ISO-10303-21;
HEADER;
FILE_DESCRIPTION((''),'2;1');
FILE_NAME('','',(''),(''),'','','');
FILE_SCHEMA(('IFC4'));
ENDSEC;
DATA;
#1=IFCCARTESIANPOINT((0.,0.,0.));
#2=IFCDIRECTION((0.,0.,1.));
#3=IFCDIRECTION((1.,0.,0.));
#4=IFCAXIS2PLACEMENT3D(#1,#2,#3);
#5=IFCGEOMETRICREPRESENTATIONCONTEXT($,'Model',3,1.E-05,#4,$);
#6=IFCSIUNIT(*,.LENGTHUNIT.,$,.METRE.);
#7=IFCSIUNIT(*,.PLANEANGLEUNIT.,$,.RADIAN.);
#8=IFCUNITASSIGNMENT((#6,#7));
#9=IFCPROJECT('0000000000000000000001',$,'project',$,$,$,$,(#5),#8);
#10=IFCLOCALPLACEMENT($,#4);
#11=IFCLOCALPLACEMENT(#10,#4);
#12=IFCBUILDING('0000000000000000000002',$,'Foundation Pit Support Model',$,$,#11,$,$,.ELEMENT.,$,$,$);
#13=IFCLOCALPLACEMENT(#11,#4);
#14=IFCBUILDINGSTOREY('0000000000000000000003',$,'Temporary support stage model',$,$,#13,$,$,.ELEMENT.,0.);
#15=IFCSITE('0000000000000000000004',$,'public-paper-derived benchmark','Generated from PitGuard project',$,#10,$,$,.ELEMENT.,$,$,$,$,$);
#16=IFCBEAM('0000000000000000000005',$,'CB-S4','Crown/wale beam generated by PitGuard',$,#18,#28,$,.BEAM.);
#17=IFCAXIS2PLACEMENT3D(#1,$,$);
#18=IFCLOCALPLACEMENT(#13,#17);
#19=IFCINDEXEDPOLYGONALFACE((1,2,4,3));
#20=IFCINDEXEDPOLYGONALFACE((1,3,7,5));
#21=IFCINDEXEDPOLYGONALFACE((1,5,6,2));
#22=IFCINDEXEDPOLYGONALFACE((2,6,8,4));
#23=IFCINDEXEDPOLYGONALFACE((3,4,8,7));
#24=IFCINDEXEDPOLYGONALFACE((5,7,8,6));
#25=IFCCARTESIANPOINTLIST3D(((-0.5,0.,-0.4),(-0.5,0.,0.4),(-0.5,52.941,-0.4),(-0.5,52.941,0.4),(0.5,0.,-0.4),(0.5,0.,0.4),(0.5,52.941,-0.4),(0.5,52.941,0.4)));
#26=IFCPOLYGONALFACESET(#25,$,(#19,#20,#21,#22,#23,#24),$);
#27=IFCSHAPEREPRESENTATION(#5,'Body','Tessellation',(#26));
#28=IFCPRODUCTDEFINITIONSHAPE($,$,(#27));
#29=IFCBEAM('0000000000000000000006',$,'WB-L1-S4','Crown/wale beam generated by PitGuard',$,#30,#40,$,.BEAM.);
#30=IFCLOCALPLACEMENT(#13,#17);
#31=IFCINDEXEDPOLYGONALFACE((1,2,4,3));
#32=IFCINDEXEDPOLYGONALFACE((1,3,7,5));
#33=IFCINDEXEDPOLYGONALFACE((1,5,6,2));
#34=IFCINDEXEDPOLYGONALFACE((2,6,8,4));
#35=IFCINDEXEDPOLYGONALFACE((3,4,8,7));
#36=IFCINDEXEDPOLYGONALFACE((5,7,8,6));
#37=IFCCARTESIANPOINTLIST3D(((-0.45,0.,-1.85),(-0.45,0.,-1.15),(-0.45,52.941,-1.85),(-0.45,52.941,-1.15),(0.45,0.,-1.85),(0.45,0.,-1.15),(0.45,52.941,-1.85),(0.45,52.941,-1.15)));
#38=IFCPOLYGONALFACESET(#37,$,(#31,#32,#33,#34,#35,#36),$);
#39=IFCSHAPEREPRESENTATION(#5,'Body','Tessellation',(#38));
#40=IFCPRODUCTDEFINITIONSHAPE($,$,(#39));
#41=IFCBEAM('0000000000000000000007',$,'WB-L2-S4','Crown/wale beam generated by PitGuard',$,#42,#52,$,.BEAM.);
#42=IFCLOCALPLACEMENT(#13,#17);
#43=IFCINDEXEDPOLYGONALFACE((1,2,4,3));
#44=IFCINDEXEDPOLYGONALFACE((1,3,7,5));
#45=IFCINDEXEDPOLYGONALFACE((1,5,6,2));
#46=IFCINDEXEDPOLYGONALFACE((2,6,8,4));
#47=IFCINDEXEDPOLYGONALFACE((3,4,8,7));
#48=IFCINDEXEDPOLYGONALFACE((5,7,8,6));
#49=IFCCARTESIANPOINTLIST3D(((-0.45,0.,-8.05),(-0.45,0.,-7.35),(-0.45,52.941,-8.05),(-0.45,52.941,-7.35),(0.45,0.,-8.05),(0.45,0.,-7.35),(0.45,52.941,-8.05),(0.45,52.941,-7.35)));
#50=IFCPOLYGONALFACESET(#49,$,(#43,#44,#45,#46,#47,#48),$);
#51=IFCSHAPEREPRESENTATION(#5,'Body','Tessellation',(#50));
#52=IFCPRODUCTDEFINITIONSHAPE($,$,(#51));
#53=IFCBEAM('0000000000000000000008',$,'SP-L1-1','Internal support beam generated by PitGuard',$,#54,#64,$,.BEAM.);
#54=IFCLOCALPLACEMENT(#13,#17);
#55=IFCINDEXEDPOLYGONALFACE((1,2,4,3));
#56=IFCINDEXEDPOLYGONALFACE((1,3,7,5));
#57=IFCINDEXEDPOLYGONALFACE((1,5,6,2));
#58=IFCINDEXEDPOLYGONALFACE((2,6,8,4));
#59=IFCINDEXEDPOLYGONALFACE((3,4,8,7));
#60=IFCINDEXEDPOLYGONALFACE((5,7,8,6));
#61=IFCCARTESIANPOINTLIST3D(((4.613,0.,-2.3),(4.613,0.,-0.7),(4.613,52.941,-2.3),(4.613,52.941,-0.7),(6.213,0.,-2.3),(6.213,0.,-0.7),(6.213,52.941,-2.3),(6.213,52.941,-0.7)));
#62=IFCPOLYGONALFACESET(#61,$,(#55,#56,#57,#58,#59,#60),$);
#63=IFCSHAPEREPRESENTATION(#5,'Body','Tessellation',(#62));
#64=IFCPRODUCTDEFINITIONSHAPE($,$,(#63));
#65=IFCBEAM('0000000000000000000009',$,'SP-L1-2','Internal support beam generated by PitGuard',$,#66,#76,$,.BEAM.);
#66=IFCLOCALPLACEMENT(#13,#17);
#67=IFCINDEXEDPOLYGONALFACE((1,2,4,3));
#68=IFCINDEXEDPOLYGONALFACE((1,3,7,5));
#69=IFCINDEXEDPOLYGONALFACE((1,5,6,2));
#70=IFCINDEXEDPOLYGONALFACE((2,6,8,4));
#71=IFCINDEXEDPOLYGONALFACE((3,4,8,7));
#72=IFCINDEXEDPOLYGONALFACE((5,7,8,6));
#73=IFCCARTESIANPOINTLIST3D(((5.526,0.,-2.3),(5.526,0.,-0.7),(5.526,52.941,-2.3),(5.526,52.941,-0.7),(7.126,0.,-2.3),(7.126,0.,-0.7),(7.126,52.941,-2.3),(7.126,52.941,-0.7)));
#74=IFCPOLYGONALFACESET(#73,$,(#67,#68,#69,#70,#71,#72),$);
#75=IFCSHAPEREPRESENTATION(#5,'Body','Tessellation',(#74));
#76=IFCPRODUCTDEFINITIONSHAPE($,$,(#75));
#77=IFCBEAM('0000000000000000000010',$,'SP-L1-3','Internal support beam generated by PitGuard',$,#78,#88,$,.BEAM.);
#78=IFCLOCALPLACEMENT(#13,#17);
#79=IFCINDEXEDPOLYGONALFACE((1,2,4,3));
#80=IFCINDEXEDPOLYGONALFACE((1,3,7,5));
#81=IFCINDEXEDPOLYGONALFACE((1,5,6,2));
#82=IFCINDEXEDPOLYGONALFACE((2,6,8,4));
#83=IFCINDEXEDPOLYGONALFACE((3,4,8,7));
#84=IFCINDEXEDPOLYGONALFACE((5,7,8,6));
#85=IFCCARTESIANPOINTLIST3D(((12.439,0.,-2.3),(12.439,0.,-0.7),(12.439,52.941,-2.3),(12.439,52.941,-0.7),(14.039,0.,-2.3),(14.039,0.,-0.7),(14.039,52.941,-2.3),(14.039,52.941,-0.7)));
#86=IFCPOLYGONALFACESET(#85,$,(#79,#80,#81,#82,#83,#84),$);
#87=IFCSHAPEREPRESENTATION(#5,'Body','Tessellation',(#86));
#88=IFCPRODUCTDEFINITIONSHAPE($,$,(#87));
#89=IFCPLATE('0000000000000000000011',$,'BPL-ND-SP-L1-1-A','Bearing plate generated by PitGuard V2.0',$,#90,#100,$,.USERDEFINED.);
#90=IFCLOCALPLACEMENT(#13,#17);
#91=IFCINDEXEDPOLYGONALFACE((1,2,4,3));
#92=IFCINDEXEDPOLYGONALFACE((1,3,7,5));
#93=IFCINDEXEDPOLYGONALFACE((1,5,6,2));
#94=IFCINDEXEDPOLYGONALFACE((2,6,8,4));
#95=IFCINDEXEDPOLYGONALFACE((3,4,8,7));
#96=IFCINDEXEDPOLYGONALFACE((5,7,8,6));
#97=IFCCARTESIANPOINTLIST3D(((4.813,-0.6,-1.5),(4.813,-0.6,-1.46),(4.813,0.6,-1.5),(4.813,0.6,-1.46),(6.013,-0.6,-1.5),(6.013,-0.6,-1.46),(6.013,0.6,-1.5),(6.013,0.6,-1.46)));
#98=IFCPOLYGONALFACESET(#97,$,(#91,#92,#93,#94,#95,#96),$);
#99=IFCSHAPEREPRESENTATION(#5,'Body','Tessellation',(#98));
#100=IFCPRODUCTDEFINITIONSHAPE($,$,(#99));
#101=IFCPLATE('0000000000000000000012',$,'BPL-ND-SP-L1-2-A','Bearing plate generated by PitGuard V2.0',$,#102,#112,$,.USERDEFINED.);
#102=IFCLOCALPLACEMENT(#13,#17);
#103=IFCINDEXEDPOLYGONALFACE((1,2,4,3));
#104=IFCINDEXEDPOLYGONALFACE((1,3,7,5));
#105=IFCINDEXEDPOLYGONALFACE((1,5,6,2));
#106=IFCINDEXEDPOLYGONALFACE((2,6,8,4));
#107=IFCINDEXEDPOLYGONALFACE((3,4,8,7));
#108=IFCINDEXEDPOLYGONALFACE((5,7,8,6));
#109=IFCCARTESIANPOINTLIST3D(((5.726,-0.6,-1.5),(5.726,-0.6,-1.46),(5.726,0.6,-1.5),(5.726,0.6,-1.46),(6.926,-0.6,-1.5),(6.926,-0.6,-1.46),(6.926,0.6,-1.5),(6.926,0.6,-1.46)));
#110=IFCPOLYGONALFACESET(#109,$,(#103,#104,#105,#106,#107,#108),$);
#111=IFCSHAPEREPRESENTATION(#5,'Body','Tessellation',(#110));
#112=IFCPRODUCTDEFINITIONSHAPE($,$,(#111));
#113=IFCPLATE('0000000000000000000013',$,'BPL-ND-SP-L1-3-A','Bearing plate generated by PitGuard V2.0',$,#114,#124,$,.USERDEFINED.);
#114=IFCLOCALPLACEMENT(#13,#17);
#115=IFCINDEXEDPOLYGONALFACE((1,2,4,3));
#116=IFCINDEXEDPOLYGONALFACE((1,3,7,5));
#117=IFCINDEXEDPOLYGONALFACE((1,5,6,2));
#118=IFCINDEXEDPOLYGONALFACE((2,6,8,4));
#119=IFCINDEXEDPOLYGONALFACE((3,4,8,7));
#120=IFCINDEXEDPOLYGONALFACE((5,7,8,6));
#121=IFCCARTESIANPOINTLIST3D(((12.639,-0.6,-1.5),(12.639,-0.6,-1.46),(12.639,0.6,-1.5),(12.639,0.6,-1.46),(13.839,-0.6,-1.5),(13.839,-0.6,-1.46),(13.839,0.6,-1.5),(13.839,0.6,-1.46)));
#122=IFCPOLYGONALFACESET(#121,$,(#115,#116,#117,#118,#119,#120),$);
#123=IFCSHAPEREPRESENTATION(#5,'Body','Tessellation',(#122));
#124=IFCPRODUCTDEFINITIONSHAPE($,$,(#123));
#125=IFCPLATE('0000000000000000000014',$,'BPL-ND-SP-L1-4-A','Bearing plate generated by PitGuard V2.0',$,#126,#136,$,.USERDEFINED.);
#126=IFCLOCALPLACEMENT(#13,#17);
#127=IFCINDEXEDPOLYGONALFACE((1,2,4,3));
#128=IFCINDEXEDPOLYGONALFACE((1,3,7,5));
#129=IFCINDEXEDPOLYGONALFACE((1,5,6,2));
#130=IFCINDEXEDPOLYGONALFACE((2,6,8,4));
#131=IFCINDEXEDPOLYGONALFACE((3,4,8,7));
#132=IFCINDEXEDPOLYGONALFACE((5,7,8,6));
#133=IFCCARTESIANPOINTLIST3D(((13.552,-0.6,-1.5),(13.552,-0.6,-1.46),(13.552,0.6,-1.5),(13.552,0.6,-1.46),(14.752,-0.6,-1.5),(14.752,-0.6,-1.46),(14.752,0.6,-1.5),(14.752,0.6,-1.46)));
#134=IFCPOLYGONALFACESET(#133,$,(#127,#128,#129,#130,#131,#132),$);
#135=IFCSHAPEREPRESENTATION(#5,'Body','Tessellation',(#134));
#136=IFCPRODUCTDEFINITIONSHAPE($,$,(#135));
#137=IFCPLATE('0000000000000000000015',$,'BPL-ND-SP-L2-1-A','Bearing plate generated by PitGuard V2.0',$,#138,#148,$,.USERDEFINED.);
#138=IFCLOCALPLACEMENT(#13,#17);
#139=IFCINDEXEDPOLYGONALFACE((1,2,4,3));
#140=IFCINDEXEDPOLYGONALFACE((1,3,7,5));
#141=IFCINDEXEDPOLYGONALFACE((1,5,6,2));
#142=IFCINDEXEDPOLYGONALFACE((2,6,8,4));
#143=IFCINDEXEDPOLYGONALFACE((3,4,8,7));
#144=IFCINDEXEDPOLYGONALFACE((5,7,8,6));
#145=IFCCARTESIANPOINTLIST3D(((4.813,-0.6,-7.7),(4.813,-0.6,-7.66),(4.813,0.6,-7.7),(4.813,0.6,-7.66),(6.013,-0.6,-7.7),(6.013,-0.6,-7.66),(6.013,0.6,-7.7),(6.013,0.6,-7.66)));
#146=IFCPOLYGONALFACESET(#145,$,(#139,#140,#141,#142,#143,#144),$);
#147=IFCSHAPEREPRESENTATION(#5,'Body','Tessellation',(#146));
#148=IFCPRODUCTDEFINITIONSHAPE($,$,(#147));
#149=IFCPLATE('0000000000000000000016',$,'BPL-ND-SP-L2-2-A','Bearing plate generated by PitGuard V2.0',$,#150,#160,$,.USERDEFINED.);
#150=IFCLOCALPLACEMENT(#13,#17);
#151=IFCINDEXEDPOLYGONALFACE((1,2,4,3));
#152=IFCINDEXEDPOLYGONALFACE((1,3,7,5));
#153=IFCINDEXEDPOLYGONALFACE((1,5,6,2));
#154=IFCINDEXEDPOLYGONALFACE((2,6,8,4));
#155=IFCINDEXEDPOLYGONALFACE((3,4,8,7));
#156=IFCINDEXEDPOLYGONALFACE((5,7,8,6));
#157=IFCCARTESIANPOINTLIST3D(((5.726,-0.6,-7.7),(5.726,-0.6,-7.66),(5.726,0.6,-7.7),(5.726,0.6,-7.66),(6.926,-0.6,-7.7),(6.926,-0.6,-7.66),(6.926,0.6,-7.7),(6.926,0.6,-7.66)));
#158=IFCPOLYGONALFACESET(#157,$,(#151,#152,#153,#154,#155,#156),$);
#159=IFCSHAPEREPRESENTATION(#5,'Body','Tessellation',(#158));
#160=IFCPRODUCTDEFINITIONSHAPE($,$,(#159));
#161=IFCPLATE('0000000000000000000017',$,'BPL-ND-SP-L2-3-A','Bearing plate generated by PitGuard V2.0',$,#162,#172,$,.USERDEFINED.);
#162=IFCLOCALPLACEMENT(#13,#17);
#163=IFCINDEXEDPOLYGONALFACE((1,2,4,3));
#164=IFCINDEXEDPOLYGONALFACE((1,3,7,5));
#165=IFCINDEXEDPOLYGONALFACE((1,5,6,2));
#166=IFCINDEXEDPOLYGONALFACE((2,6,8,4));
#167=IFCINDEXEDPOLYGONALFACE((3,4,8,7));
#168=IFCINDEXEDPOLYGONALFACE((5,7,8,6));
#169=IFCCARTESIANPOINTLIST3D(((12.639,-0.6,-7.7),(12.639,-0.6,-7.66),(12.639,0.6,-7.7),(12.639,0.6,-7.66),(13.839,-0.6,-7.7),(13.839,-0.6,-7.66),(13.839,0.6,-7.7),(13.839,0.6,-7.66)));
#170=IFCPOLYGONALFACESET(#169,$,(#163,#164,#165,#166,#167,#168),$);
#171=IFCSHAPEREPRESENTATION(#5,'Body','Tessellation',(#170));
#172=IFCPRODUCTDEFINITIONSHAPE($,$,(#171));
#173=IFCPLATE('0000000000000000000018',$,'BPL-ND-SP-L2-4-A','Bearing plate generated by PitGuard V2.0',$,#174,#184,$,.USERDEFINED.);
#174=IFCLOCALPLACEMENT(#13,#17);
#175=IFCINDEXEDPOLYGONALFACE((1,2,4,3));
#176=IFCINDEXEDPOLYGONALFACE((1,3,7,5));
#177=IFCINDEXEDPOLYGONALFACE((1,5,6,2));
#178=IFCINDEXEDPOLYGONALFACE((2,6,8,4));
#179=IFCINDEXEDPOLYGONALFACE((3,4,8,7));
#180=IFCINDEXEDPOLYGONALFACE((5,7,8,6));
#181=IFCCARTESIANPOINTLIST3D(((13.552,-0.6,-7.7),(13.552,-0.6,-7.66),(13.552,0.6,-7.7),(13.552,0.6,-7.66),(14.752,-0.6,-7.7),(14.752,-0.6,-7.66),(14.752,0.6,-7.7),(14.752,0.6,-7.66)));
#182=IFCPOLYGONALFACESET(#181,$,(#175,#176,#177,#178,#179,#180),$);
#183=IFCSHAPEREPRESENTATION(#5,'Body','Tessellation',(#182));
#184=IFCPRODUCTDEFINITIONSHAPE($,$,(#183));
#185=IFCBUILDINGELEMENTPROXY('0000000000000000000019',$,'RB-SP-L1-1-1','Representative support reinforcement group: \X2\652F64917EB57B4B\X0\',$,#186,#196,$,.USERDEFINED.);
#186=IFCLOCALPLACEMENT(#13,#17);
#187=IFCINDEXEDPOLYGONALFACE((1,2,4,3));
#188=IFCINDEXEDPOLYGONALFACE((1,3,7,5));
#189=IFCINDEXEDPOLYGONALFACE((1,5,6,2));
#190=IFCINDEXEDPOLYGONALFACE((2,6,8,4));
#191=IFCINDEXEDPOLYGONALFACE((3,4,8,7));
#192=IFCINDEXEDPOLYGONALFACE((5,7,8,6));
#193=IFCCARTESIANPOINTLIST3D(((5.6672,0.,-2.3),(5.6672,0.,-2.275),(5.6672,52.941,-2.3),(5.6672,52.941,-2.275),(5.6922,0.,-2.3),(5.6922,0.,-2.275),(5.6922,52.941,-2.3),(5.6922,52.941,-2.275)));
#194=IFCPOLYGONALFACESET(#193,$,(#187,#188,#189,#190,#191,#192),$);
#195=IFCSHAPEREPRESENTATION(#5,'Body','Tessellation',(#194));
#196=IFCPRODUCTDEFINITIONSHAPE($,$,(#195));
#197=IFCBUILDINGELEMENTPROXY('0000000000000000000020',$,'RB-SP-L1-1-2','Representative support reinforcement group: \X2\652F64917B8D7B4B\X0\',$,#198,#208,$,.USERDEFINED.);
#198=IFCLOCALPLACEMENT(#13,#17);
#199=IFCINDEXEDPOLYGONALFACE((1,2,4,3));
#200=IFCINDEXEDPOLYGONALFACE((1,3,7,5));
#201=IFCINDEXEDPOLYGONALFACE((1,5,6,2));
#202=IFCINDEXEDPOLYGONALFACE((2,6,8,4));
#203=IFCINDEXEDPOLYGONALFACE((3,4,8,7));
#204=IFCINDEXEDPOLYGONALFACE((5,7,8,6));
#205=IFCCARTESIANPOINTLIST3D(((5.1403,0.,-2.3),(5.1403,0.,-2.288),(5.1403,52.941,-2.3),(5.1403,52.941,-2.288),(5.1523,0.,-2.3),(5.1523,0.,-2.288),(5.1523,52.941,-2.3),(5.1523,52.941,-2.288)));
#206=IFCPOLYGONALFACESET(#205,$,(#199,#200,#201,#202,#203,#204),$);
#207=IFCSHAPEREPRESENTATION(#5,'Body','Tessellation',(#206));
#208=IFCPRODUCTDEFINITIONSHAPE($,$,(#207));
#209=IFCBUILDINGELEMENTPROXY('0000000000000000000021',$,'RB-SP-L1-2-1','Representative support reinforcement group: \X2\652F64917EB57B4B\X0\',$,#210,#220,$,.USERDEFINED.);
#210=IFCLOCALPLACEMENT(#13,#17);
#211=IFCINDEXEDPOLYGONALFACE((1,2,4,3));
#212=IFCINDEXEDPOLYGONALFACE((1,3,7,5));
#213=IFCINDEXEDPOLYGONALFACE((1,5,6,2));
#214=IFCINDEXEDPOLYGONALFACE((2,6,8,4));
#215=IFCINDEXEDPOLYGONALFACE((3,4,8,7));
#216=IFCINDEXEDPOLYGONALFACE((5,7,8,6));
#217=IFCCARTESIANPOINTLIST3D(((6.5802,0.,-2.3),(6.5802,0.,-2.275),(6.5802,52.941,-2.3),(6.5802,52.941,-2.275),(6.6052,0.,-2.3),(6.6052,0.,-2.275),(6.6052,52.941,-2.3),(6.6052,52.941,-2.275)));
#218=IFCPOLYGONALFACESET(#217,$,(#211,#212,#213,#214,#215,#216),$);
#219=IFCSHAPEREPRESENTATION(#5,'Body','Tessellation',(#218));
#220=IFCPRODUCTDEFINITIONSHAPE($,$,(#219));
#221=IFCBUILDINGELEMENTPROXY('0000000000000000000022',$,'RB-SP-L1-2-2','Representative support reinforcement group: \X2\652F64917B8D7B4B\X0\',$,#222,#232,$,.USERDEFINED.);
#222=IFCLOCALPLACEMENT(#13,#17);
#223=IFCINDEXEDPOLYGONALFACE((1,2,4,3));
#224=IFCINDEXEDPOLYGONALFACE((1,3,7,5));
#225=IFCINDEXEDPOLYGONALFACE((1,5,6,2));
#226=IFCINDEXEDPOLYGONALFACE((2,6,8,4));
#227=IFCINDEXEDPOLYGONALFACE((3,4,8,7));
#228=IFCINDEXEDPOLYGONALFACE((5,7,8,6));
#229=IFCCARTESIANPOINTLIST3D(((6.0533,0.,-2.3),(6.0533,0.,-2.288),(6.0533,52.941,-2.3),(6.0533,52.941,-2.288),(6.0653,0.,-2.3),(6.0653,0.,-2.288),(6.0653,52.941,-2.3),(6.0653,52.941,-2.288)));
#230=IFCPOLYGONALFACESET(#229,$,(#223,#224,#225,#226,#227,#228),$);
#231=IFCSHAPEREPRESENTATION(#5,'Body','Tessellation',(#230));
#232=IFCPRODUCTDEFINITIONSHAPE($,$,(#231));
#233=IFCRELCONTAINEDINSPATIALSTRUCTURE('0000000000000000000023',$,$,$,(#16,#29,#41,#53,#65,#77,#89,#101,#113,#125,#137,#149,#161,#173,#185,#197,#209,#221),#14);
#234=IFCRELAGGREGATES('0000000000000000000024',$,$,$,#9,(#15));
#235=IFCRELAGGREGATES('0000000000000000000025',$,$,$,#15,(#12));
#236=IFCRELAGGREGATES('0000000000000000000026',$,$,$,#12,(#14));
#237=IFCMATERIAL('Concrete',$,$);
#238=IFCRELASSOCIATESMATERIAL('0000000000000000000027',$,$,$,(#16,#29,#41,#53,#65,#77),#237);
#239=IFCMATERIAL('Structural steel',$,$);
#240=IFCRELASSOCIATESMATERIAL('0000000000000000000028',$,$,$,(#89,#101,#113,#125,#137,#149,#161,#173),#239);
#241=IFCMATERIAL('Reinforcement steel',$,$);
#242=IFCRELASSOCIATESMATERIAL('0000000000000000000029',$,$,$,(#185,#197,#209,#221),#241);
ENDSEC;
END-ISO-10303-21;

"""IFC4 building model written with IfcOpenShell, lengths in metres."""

from ifc_helpers import new_model, si_unit, frame, origin_with_axes, origin_2d, place, context, project, spatial, rectangle, extrude, material, element, save


model = new_model("IFC4")

# Units and contexts
model_context = context("Model", 3, precision=1e-05, world=origin_with_axes())
ifc_project = project(units=[si_unit("LENGTHUNIT", "METRE"), si_unit("PLANEANGLEUNIT", "RADIAN")], contexts=[model_context])

# Site, building, storey
site_placement = place(None, origin_with_axes())
site = spatial("IfcSite", under=ifc_project, at=site_placement, Name="public-paper-derived benchmark", Description="Generated from PitGuard project", CompositionType="ELEMENT")
building_placement = place(site_placement, origin_with_axes())
building = spatial("IfcBuilding", under=site, at=building_placement, Name="Foundation Pit Support Model", CompositionType="ELEMENT")
storey_placement = place(building_placement, origin_with_axes())
storey = spatial("IfcBuildingStorey", under=building, at=storey_placement, Name="Temporary support stage model", CompositionType="ELEMENT", Elevation=0.0)

# Beams
ifc_material_1 = material(Name="Concrete")
beam_placement = place(storey_placement, frame((0.0, 26.4705, -0.4), z_axis=(0.0, 0.0, 1.0), x_axis=(0.0, -1.0, 0.0)))
element("IfcBeam", 1, at=beam_placement, inside=storey, material=ifc_material_1, Name="CB-S4", Description="Crown/wale beam generated by PitGuard", PredefinedType="BEAM", context=model_context, shape_type="SweptSolid", body=[
    extrude(rectangle(XDim=52.941, YDim=1.0, at=origin_2d()), origin_with_axes(), (0.0, 0.0, 1.0), 0.8),
])
for number, where, z_axis, x_axis, name in (
    (2, (0.0, 26.4705, -1.85), (0.0, 0.0, 1.0), (0.0, -1.0, 0.0), "WB-L1-S4"),
    (3, (0.0, 26.4705, -8.05), (0.0, 0.0, 1.0), (0.0, -1.0, 0.0), "WB-L2-S4"),
):
    element("IfcBeam", number, at=place(storey_placement, frame(where, z_axis=z_axis, x_axis=x_axis)), inside=storey, material=ifc_material_1, Name=name, Description="Crown/wale beam generated by PitGuard", PredefinedType="BEAM", context=model_context, shape_type="SweptSolid", body=[
        extrude(rectangle(XDim=52.941, YDim=0.9, at=origin_2d()), origin_with_axes(), (0.0, 0.0, 1.0), 0.7),
    ])
for number, where, z_axis, x_axis, name in (
    (4, (5.413, 26.4705, -2.3), (0.0, 0.0, 1.0), (0.0, 1.0, 0.0), "SP-L1-1"),
    (5, (6.326, 26.4705, -2.3), (0.0, 0.0, 1.0), (0.0, 1.0, 0.0), "SP-L1-2"),
    (6, (13.239, 26.4705, -2.3), (0.0, 0.0, 1.0), (0.0, 1.0, 0.0), "SP-L1-3"),
):
    element("IfcBeam", number, at=place(storey_placement, frame(where, z_axis=z_axis, x_axis=x_axis)), inside=storey, material=ifc_material_1, Name=name, Description="Internal support beam generated by PitGuard", PredefinedType="BEAM", context=model_context, shape_type="SweptSolid", body=[
        extrude(rectangle(XDim=52.941, YDim=1.6, at=origin_2d()), origin_with_axes(), (0.0, 0.0, 1.0), 1.6),
    ])

# Plates
ifc_material_2 = material(Name="Structural steel")
for number, where, z_axis, x_axis, name in (
    (7, (5.413, 0.0, -1.5), (0.0, 0.0, 1.0), (1.0, 0.0, 0.0), "BPL-ND-SP-L1-1-A"),
    (8, (6.326, 0.0, -1.5), (0.0, 0.0, 1.0), (1.0, 0.0, 0.0), "BPL-ND-SP-L1-2-A"),
    (9, (13.239, 0.0, -1.5), (0.0, 0.0, 1.0), (1.0, 0.0, 0.0), "BPL-ND-SP-L1-3-A"),
    (10, (14.152, 0.0, -1.5), (0.0, 0.0, 1.0), (1.0, 0.0, 0.0), "BPL-ND-SP-L1-4-A"),
    (11, (5.413, 0.0, -7.7), (0.0, 0.0, 1.0), (1.0, 0.0, 0.0), "BPL-ND-SP-L2-1-A"),
    (12, (6.326, 0.0, -7.7), (0.0, 0.0, 1.0), (1.0, 0.0, 0.0), "BPL-ND-SP-L2-2-A"),
    (13, (13.239, 0.0, -7.7), (0.0, 0.0, 1.0), (1.0, 0.0, 0.0), "BPL-ND-SP-L2-3-A"),
    (14, (14.152, 0.0, -7.7), (0.0, 0.0, 1.0), (1.0, 0.0, 0.0), "BPL-ND-SP-L2-4-A"),
):
    element("IfcPlate", number, at=place(storey_placement, frame(where, z_axis=z_axis, x_axis=x_axis)), inside=storey, material=ifc_material_2, Name=name, Description="Bearing plate generated by PitGuard V2.0", PredefinedType="USERDEFINED", context=model_context, shape_type="SweptSolid", body=[
        extrude(rectangle(XDim=1.2, YDim=1.2, at=origin_2d()), origin_with_axes(), (0.0, 0.0, 1.0), 0.04),
    ])

# Building element proxies
ifc_material_3 = material(Name="Reinforcement steel")
proxy_1_placement = place(storey_placement, frame((5.6797, 26.4705, -2.3), z_axis=(0.0, 0.0, 1.0), x_axis=(0.0, 1.0, 0.0)))
element("IfcBuildingElementProxy", 15, at=proxy_1_placement, inside=storey, material=ifc_material_3, Name="RB-SP-L1-1-1", Description="Representative support reinforcement group: 支撑纵筋", PredefinedType="USERDEFINED", context=model_context, shape_type="SweptSolid", body=[
    extrude(rectangle(XDim=52.941, YDim=0.025, at=origin_2d()), origin_with_axes(), (0.0, 0.0, 1.0), 0.025),
])
proxy_2_placement = place(storey_placement, frame((5.1463, 26.4705, -2.3), z_axis=(0.0, 0.0, 1.0), x_axis=(0.0, 1.0, 0.0)))
element("IfcBuildingElementProxy", 16, at=proxy_2_placement, inside=storey, material=ifc_material_3, Name="RB-SP-L1-1-2", Description="Representative support reinforcement group: 支撑箍筋", PredefinedType="USERDEFINED", context=model_context, shape_type="SweptSolid", body=[
    extrude(rectangle(XDim=52.941, YDim=0.012, at=origin_2d()), origin_with_axes(), (0.0, 0.0, 1.0), 0.012),
])
proxy_3_placement = place(storey_placement, frame((6.5927, 26.4705, -2.3), z_axis=(0.0, 0.0, 1.0), x_axis=(0.0, 1.0, 0.0)))
element("IfcBuildingElementProxy", 17, at=proxy_3_placement, inside=storey, material=ifc_material_3, Name="RB-SP-L1-2-1", Description="Representative support reinforcement group: 支撑纵筋", PredefinedType="USERDEFINED", context=model_context, shape_type="SweptSolid", body=[
    extrude(rectangle(XDim=52.941, YDim=0.025, at=origin_2d()), origin_with_axes(), (0.0, 0.0, 1.0), 0.025),
])
proxy_4_placement = place(storey_placement, frame((6.0593, 26.4705, -2.3), z_axis=(0.0, 0.0, 1.0), x_axis=(0.0, 1.0, 0.0)))
element("IfcBuildingElementProxy", 18, at=proxy_4_placement, inside=storey, material=ifc_material_3, Name="RB-SP-L1-2-2", Description="Representative support reinforcement group: 支撑箍筋", PredefinedType="USERDEFINED", context=model_context, shape_type="SweptSolid", body=[
    extrude(rectangle(XDim=52.941, YDim=0.012, at=origin_2d()), origin_with_axes(), (0.0, 0.0, 1.0), 0.012),
])

save(model, "model.ifc")
